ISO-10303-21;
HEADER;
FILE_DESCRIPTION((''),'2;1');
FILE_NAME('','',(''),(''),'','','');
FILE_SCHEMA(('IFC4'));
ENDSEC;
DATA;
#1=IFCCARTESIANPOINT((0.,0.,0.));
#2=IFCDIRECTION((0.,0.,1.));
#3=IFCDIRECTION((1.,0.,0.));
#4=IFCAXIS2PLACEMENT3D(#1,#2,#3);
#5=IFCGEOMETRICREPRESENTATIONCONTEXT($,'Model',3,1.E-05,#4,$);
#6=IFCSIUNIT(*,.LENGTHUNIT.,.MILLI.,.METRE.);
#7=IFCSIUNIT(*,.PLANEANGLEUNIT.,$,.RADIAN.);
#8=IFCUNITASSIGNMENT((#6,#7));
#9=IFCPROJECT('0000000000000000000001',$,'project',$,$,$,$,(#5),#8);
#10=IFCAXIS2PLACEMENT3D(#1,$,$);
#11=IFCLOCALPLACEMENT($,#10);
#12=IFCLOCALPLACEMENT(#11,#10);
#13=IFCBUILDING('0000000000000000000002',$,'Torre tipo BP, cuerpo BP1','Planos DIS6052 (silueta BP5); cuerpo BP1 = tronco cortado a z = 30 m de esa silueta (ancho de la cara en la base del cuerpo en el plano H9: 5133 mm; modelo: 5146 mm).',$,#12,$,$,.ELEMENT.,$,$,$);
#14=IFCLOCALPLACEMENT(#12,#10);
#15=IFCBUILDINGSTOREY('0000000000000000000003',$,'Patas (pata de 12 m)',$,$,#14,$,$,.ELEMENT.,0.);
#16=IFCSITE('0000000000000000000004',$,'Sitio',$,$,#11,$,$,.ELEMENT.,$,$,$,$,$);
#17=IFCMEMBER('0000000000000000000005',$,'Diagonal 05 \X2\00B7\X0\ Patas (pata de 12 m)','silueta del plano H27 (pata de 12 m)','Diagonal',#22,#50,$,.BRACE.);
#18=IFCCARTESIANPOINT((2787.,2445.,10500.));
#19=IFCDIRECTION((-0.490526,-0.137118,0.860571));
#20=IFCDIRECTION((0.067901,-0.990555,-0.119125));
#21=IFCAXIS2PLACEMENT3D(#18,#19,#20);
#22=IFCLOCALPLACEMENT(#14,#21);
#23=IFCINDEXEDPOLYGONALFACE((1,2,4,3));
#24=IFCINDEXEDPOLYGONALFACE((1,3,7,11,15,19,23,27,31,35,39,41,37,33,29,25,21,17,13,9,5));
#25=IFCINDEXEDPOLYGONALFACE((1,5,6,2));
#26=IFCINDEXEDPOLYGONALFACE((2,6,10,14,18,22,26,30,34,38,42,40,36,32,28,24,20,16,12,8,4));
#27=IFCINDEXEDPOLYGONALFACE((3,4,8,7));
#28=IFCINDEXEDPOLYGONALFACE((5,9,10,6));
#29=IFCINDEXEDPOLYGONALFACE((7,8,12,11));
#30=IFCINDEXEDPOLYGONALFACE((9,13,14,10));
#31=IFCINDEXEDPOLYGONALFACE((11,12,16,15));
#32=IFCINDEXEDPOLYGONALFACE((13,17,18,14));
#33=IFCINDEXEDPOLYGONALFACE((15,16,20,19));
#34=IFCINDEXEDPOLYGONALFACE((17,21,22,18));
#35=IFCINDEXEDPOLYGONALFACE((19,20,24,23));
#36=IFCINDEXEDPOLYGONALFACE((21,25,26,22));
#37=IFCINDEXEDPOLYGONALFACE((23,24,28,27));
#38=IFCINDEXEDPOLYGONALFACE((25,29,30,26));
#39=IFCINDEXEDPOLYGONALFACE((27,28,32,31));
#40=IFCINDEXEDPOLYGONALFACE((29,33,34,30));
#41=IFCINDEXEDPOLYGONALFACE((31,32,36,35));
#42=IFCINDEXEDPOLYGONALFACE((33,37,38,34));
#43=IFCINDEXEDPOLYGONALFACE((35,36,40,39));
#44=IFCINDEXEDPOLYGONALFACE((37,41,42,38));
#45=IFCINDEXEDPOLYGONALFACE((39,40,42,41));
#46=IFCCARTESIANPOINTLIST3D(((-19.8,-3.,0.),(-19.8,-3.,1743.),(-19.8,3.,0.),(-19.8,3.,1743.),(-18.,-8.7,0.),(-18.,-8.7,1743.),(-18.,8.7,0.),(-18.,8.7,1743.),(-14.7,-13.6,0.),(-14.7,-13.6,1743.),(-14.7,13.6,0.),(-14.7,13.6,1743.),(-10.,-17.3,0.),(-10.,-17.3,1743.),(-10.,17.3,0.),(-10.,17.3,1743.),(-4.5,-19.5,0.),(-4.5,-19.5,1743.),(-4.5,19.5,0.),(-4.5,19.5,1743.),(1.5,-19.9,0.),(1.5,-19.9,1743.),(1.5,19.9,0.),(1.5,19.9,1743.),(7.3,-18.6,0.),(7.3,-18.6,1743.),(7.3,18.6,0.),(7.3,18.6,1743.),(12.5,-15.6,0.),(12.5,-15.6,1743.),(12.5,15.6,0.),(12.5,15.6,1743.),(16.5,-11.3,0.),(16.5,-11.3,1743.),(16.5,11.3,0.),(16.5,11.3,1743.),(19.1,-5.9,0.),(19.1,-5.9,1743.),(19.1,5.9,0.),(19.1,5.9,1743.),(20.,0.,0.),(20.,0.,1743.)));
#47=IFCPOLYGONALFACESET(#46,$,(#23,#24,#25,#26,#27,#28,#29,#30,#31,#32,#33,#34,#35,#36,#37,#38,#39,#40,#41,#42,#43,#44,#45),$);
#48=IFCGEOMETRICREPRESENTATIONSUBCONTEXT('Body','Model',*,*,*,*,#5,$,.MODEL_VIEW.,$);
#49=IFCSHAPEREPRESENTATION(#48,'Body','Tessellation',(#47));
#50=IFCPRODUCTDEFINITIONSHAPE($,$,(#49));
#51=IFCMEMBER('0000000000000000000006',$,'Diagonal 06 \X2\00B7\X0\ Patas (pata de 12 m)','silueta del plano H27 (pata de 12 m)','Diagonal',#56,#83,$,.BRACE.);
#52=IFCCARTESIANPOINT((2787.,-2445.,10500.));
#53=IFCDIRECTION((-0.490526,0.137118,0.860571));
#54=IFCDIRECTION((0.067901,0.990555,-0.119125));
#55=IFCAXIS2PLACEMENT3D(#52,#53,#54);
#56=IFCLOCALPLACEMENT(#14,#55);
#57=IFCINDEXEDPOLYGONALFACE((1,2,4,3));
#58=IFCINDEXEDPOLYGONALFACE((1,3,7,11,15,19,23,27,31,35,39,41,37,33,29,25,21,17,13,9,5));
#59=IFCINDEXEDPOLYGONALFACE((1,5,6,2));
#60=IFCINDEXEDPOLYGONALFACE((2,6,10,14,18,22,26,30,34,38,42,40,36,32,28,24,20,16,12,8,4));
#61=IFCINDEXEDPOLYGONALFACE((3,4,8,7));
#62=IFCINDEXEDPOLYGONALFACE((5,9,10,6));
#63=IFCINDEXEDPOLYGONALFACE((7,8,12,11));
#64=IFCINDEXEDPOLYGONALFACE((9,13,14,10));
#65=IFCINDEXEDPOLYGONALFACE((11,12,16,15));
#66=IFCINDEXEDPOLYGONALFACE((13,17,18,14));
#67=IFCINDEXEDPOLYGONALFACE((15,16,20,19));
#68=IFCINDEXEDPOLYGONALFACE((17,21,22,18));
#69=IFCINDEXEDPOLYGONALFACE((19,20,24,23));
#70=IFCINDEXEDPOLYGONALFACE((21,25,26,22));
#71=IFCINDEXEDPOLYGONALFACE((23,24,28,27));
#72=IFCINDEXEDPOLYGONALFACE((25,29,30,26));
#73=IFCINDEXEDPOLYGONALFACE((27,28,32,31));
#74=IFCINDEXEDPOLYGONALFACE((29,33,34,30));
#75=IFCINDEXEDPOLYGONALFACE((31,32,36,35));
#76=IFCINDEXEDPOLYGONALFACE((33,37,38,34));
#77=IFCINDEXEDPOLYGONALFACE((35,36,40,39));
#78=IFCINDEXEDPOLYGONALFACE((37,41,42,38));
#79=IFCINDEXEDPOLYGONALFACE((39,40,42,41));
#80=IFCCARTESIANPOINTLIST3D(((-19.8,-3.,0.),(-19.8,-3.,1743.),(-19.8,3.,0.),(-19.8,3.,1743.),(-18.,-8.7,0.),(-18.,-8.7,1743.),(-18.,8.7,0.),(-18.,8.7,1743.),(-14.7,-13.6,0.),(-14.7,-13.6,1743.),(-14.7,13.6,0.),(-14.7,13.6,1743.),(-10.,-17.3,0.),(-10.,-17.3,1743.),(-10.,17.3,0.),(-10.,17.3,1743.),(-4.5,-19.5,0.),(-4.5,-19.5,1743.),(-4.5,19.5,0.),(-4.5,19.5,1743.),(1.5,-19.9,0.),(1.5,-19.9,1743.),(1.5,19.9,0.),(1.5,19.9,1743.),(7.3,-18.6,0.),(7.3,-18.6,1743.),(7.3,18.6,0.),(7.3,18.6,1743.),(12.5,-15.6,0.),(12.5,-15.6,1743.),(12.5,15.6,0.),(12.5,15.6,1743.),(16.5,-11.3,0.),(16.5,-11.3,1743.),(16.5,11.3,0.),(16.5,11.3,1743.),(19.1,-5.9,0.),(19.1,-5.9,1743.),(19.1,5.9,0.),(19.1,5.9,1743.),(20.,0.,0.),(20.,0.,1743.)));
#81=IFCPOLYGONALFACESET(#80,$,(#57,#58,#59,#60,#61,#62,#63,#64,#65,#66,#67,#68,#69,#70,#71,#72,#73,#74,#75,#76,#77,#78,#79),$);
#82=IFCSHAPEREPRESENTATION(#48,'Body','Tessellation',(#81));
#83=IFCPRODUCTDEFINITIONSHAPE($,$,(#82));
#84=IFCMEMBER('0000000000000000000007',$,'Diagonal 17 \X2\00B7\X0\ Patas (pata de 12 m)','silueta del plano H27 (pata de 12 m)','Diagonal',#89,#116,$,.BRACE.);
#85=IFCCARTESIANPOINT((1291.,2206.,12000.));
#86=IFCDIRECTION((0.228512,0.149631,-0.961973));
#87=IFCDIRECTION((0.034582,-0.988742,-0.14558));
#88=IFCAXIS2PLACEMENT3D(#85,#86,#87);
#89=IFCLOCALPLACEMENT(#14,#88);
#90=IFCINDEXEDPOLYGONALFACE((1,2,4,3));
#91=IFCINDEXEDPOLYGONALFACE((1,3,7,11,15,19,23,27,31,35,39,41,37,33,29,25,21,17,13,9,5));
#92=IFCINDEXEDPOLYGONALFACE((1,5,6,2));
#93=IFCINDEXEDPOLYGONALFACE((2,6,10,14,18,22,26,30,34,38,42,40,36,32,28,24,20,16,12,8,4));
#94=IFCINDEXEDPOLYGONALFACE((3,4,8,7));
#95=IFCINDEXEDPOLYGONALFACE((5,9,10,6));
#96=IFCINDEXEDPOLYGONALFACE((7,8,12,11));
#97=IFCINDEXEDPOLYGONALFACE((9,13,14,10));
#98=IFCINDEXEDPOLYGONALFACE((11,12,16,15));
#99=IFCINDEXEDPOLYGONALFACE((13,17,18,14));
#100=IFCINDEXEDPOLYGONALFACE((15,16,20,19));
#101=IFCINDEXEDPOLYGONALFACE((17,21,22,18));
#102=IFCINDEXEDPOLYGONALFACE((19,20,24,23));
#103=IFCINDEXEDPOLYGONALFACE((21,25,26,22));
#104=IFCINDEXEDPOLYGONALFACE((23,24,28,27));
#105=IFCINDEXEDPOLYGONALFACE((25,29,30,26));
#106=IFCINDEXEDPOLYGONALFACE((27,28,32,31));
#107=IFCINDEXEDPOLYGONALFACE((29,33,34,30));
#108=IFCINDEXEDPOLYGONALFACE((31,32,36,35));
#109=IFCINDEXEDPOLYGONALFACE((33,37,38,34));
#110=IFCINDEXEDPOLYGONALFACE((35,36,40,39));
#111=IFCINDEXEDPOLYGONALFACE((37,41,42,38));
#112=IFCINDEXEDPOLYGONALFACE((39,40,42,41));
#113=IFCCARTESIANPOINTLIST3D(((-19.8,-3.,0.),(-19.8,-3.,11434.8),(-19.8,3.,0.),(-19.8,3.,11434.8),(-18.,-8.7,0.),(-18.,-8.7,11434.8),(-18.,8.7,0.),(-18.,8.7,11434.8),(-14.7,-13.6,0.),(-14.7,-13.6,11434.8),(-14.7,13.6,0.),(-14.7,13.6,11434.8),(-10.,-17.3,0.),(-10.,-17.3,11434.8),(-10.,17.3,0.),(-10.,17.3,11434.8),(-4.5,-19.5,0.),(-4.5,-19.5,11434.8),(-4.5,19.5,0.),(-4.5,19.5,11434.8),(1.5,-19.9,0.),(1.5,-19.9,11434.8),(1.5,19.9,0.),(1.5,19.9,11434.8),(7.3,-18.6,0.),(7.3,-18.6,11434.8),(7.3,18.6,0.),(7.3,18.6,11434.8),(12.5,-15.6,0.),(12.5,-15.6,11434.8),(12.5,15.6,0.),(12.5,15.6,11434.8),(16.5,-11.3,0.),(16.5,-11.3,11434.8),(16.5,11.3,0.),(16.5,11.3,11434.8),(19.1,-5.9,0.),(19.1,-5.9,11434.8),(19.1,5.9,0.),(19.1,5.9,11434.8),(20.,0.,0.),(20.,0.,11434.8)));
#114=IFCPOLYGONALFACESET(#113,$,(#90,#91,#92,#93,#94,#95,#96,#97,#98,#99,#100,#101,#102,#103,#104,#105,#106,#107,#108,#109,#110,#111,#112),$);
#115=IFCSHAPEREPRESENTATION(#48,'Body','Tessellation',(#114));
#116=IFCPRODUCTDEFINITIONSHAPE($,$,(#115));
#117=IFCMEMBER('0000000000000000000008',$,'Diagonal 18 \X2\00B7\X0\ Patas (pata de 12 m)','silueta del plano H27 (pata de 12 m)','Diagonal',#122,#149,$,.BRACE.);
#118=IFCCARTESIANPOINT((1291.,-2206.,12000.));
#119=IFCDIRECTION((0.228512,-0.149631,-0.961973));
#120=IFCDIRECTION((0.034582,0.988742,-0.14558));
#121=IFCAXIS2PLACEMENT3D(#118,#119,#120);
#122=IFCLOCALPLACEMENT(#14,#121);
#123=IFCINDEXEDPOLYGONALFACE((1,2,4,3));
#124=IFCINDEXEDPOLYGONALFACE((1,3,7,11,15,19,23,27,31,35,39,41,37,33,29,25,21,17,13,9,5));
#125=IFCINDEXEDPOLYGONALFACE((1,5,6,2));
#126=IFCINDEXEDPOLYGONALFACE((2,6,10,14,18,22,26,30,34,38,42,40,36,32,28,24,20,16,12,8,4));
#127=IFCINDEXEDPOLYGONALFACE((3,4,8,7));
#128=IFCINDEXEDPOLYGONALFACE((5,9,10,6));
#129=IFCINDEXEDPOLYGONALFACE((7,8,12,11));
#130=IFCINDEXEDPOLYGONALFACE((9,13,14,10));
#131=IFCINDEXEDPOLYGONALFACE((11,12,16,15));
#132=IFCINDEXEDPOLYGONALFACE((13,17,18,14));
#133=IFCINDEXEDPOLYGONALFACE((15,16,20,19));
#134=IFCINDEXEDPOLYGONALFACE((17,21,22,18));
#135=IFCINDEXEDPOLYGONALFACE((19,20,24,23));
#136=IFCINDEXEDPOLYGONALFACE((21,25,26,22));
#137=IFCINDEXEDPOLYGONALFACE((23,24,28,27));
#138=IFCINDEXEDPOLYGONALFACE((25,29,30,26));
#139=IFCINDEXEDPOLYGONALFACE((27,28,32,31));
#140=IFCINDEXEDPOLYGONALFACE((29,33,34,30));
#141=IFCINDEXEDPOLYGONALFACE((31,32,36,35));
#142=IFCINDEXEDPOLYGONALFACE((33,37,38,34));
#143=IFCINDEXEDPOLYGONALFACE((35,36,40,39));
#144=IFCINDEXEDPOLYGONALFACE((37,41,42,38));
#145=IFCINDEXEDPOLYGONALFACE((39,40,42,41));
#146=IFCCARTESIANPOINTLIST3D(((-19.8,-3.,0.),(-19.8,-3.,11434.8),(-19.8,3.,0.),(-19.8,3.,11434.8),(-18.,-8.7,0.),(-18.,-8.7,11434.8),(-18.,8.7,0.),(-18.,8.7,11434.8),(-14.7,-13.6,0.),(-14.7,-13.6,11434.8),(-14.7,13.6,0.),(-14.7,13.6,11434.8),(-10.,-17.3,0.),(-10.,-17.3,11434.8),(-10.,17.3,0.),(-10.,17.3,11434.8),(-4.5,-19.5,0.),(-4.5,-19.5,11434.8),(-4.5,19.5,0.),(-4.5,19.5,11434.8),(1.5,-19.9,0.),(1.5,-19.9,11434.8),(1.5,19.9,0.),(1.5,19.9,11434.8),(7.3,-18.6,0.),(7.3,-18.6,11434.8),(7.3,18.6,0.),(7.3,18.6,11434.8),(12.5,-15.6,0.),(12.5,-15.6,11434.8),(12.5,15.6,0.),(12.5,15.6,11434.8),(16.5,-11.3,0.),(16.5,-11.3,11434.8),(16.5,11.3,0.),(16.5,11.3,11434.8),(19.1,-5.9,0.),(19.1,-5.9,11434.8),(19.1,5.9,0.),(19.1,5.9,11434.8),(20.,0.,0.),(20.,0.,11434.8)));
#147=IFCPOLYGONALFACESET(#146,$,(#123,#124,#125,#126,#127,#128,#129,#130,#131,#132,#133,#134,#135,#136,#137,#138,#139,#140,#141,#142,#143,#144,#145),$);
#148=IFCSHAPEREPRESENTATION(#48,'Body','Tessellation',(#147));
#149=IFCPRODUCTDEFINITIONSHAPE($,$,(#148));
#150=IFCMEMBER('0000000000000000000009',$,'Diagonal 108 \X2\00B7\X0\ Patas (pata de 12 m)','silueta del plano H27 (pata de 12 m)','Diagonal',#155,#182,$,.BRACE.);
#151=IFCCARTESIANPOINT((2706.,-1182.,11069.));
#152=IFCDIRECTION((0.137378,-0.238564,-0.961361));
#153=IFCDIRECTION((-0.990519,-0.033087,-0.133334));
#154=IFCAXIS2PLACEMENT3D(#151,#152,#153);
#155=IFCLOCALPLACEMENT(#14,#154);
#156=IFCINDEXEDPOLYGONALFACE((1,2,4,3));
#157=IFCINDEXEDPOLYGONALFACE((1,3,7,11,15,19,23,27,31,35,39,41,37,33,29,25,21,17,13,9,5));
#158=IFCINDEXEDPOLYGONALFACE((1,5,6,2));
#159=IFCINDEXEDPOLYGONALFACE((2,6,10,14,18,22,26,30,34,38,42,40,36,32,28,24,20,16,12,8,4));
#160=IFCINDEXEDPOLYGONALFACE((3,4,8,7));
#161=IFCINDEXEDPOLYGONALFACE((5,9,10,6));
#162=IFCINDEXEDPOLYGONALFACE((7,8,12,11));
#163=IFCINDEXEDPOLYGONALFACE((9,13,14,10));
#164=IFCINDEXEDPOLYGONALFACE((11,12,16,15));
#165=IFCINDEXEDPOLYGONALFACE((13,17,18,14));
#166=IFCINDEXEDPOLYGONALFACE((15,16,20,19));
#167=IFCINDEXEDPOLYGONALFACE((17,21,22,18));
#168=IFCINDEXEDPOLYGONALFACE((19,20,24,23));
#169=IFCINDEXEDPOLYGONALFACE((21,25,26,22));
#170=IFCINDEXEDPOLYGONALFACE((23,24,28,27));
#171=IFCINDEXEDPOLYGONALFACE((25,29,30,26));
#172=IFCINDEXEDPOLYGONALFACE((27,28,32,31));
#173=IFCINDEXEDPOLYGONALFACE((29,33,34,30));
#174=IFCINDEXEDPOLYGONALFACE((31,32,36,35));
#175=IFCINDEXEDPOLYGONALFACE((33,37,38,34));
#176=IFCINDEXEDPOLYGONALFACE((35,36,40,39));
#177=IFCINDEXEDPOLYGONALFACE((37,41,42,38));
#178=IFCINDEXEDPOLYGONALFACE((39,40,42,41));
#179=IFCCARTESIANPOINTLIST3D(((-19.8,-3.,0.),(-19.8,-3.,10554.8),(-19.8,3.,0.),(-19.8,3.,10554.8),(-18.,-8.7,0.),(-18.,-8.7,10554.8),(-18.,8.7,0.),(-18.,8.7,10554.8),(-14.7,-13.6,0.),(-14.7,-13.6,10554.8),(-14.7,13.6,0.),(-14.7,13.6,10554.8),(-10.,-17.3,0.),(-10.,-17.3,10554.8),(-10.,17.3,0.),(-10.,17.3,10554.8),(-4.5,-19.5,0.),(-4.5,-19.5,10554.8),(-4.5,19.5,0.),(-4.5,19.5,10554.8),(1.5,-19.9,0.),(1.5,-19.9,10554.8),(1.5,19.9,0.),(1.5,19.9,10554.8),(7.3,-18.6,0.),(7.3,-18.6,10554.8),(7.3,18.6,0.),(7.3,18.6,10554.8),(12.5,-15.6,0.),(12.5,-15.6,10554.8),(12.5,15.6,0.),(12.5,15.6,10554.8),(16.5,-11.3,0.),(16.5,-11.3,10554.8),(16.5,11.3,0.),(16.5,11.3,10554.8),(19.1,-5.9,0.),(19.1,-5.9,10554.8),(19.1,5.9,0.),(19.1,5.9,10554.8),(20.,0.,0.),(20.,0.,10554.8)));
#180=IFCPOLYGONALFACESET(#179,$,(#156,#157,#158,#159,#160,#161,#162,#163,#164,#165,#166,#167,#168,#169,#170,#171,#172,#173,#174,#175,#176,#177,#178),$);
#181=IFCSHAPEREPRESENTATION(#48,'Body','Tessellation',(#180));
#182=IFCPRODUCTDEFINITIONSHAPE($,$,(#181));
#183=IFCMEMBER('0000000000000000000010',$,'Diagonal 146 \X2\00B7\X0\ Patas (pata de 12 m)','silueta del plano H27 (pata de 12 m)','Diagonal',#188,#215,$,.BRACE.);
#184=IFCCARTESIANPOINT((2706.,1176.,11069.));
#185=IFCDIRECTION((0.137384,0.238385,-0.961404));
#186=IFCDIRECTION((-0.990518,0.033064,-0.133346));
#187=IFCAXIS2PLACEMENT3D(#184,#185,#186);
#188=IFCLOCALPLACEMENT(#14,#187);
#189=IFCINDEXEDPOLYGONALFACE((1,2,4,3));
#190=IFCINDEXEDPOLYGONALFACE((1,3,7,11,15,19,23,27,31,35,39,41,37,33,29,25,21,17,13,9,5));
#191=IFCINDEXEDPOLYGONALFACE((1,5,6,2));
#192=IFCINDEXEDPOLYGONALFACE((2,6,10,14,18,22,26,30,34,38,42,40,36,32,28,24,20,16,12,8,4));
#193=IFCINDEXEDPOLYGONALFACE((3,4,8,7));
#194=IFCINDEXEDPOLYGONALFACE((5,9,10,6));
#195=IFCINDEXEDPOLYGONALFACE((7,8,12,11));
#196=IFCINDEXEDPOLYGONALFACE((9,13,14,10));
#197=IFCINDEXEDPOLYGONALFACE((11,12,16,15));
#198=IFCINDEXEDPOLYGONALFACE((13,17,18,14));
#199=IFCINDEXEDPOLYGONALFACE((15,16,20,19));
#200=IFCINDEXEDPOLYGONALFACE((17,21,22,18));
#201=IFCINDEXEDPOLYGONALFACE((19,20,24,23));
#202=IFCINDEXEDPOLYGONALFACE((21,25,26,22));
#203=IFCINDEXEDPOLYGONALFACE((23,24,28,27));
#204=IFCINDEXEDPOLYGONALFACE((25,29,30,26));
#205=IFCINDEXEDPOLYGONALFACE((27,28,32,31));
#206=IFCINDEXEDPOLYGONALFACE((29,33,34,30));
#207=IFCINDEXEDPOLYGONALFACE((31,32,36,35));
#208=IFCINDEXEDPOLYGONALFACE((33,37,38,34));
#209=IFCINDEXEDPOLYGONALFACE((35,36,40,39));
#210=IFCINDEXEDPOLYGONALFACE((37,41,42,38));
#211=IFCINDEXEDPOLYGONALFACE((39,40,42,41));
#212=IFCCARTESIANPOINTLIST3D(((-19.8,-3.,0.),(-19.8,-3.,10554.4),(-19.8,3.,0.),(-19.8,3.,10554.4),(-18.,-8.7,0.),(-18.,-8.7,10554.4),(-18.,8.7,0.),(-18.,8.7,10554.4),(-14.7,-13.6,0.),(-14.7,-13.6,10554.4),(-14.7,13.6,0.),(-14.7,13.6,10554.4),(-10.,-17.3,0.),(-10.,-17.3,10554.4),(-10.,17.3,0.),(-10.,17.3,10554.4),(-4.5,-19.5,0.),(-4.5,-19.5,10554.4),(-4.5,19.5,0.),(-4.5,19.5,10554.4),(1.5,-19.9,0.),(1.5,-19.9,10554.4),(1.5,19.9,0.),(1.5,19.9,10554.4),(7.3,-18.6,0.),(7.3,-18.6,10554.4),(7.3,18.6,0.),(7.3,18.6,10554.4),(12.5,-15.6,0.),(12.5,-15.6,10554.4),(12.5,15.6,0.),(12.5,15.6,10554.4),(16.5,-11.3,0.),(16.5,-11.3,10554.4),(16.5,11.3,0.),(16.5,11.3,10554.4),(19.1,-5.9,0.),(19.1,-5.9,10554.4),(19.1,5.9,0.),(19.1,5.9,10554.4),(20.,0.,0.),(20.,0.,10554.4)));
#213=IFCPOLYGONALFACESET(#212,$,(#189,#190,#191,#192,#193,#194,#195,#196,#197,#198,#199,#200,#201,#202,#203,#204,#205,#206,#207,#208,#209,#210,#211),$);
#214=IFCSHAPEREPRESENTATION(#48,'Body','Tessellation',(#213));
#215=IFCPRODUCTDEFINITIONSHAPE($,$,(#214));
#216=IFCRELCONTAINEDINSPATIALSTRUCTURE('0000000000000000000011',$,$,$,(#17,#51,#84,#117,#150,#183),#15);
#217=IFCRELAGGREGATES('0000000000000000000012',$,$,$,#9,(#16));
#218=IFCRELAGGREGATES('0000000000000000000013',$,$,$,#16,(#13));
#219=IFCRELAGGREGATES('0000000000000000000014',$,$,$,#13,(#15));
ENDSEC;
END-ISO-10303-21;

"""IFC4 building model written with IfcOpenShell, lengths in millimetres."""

from ifc_helpers import new_model, si_unit, frame, origin, origin_with_axes, place, context, subcontext, project, spatial, circle, extrude, element, save


model = new_model("IFC4")

# Units and contexts
model_context = context("Model", 3, precision=1e-05, world=origin_with_axes())
body_context = subcontext(model_context, "Body", "Model", "MODEL_VIEW")
ifc_project = project(units=[si_unit("LENGTHUNIT", "METRE", prefix="MILLI"), si_unit("PLANEANGLEUNIT", "RADIAN")], contexts=[model_context])

# Site, building, storey
site_placement = place(None, origin())
site = spatial("IfcSite", under=ifc_project, at=site_placement, Name="Sitio", CompositionType="ELEMENT")
building_placement = place(site_placement, origin())
building = spatial("IfcBuilding", under=site, at=building_placement, Name="Torre tipo BP, cuerpo BP1", Description="Planos DIS6052 (silueta BP5); cuerpo BP1 = tronco cortado a z = 30 m de esa silueta (ancho de la cara en la base del cuerpo en el plano H9: 5133 mm; modelo: 5146 mm).", CompositionType="ELEMENT")
storey_placement = place(building_placement, origin())
storey = spatial("IfcBuildingStorey", under=building, at=storey_placement, Name="Patas (pata de 12 m)", CompositionType="ELEMENT", Elevation=0.0)

# Members
for number, where, z_axis, x_axis, name in (
    (1, (2787.0, 2445.0, 10500.0), (-0.490526, -0.137118, 0.860571), (0.067901, -0.990555, -0.119125), "Diagonal 05 · Patas (pata de 12 m)"),
    (2, (2787.0, -2445.0, 10500.0), (-0.490526, 0.137118, 0.860571), (0.067901, 0.990555, -0.119125), "Diagonal 06 · Patas (pata de 12 m)"),
):
    element("IfcMember", number, at=place(storey_placement, frame(where, z_axis=z_axis, x_axis=x_axis)), inside=storey, Name=name, Description="silueta del plano H27 (pata de 12 m)", ObjectType="Diagonal", PredefinedType="BRACE", context=body_context, shape_type="SweptSolid", body=[
        extrude(circle(Radius=20.0), None, (0.0, 0.0, 1.0), 1743.0),
    ])
for number, where, z_axis, x_axis, name in (
    (3, (1291.0, 2206.0, 12000.0), (0.228512, 0.149631, -0.961973), (0.034582, -0.988742, -0.14558), "Diagonal 17 · Patas (pata de 12 m)"),
    (4, (1291.0, -2206.0, 12000.0), (0.228512, -0.149631, -0.961973), (0.034582, 0.988742, -0.14558), "Diagonal 18 · Patas (pata de 12 m)"),
):
    element("IfcMember", number, at=place(storey_placement, frame(where, z_axis=z_axis, x_axis=x_axis)), inside=storey, Name=name, Description="silueta del plano H27 (pata de 12 m)", ObjectType="Diagonal", PredefinedType="BRACE", context=body_context, shape_type="SweptSolid", body=[
        extrude(circle(Radius=20.0), None, (0.0, 0.0, 1.0), 11434.8),
    ])
member_1_placement = place(storey_placement, frame((2706.0, -1182.0, 11069.0), z_axis=(0.137378, -0.238564, -0.961361), x_axis=(-0.990519, -0.033087, -0.133334)))
element("IfcMember", 5, at=member_1_placement, inside=storey, Name="Diagonal 108 · Patas (pata de 12 m)", Description="silueta del plano H27 (pata de 12 m)", ObjectType="Diagonal", PredefinedType="BRACE", context=body_context, shape_type="SweptSolid", body=[
    extrude(circle(Radius=20.0), None, (0.0, 0.0, 1.0), 10554.8),
])
member_2_placement = place(storey_placement, frame((2706.0, 1176.0, 11069.0), z_axis=(0.137384, 0.238385, -0.961404), x_axis=(-0.990518, 0.033064, -0.133346)))
element("IfcMember", 6, at=member_2_placement, inside=storey, Name="Diagonal 146 · Patas (pata de 12 m)", Description="silueta del plano H27 (pata de 12 m)", ObjectType="Diagonal", PredefinedType="BRACE", context=body_context, shape_type="SweptSolid", body=[
    extrude(circle(Radius=20.0), None, (0.0, 0.0, 1.0), 10554.4),
])

save(model, "model.ifc")
